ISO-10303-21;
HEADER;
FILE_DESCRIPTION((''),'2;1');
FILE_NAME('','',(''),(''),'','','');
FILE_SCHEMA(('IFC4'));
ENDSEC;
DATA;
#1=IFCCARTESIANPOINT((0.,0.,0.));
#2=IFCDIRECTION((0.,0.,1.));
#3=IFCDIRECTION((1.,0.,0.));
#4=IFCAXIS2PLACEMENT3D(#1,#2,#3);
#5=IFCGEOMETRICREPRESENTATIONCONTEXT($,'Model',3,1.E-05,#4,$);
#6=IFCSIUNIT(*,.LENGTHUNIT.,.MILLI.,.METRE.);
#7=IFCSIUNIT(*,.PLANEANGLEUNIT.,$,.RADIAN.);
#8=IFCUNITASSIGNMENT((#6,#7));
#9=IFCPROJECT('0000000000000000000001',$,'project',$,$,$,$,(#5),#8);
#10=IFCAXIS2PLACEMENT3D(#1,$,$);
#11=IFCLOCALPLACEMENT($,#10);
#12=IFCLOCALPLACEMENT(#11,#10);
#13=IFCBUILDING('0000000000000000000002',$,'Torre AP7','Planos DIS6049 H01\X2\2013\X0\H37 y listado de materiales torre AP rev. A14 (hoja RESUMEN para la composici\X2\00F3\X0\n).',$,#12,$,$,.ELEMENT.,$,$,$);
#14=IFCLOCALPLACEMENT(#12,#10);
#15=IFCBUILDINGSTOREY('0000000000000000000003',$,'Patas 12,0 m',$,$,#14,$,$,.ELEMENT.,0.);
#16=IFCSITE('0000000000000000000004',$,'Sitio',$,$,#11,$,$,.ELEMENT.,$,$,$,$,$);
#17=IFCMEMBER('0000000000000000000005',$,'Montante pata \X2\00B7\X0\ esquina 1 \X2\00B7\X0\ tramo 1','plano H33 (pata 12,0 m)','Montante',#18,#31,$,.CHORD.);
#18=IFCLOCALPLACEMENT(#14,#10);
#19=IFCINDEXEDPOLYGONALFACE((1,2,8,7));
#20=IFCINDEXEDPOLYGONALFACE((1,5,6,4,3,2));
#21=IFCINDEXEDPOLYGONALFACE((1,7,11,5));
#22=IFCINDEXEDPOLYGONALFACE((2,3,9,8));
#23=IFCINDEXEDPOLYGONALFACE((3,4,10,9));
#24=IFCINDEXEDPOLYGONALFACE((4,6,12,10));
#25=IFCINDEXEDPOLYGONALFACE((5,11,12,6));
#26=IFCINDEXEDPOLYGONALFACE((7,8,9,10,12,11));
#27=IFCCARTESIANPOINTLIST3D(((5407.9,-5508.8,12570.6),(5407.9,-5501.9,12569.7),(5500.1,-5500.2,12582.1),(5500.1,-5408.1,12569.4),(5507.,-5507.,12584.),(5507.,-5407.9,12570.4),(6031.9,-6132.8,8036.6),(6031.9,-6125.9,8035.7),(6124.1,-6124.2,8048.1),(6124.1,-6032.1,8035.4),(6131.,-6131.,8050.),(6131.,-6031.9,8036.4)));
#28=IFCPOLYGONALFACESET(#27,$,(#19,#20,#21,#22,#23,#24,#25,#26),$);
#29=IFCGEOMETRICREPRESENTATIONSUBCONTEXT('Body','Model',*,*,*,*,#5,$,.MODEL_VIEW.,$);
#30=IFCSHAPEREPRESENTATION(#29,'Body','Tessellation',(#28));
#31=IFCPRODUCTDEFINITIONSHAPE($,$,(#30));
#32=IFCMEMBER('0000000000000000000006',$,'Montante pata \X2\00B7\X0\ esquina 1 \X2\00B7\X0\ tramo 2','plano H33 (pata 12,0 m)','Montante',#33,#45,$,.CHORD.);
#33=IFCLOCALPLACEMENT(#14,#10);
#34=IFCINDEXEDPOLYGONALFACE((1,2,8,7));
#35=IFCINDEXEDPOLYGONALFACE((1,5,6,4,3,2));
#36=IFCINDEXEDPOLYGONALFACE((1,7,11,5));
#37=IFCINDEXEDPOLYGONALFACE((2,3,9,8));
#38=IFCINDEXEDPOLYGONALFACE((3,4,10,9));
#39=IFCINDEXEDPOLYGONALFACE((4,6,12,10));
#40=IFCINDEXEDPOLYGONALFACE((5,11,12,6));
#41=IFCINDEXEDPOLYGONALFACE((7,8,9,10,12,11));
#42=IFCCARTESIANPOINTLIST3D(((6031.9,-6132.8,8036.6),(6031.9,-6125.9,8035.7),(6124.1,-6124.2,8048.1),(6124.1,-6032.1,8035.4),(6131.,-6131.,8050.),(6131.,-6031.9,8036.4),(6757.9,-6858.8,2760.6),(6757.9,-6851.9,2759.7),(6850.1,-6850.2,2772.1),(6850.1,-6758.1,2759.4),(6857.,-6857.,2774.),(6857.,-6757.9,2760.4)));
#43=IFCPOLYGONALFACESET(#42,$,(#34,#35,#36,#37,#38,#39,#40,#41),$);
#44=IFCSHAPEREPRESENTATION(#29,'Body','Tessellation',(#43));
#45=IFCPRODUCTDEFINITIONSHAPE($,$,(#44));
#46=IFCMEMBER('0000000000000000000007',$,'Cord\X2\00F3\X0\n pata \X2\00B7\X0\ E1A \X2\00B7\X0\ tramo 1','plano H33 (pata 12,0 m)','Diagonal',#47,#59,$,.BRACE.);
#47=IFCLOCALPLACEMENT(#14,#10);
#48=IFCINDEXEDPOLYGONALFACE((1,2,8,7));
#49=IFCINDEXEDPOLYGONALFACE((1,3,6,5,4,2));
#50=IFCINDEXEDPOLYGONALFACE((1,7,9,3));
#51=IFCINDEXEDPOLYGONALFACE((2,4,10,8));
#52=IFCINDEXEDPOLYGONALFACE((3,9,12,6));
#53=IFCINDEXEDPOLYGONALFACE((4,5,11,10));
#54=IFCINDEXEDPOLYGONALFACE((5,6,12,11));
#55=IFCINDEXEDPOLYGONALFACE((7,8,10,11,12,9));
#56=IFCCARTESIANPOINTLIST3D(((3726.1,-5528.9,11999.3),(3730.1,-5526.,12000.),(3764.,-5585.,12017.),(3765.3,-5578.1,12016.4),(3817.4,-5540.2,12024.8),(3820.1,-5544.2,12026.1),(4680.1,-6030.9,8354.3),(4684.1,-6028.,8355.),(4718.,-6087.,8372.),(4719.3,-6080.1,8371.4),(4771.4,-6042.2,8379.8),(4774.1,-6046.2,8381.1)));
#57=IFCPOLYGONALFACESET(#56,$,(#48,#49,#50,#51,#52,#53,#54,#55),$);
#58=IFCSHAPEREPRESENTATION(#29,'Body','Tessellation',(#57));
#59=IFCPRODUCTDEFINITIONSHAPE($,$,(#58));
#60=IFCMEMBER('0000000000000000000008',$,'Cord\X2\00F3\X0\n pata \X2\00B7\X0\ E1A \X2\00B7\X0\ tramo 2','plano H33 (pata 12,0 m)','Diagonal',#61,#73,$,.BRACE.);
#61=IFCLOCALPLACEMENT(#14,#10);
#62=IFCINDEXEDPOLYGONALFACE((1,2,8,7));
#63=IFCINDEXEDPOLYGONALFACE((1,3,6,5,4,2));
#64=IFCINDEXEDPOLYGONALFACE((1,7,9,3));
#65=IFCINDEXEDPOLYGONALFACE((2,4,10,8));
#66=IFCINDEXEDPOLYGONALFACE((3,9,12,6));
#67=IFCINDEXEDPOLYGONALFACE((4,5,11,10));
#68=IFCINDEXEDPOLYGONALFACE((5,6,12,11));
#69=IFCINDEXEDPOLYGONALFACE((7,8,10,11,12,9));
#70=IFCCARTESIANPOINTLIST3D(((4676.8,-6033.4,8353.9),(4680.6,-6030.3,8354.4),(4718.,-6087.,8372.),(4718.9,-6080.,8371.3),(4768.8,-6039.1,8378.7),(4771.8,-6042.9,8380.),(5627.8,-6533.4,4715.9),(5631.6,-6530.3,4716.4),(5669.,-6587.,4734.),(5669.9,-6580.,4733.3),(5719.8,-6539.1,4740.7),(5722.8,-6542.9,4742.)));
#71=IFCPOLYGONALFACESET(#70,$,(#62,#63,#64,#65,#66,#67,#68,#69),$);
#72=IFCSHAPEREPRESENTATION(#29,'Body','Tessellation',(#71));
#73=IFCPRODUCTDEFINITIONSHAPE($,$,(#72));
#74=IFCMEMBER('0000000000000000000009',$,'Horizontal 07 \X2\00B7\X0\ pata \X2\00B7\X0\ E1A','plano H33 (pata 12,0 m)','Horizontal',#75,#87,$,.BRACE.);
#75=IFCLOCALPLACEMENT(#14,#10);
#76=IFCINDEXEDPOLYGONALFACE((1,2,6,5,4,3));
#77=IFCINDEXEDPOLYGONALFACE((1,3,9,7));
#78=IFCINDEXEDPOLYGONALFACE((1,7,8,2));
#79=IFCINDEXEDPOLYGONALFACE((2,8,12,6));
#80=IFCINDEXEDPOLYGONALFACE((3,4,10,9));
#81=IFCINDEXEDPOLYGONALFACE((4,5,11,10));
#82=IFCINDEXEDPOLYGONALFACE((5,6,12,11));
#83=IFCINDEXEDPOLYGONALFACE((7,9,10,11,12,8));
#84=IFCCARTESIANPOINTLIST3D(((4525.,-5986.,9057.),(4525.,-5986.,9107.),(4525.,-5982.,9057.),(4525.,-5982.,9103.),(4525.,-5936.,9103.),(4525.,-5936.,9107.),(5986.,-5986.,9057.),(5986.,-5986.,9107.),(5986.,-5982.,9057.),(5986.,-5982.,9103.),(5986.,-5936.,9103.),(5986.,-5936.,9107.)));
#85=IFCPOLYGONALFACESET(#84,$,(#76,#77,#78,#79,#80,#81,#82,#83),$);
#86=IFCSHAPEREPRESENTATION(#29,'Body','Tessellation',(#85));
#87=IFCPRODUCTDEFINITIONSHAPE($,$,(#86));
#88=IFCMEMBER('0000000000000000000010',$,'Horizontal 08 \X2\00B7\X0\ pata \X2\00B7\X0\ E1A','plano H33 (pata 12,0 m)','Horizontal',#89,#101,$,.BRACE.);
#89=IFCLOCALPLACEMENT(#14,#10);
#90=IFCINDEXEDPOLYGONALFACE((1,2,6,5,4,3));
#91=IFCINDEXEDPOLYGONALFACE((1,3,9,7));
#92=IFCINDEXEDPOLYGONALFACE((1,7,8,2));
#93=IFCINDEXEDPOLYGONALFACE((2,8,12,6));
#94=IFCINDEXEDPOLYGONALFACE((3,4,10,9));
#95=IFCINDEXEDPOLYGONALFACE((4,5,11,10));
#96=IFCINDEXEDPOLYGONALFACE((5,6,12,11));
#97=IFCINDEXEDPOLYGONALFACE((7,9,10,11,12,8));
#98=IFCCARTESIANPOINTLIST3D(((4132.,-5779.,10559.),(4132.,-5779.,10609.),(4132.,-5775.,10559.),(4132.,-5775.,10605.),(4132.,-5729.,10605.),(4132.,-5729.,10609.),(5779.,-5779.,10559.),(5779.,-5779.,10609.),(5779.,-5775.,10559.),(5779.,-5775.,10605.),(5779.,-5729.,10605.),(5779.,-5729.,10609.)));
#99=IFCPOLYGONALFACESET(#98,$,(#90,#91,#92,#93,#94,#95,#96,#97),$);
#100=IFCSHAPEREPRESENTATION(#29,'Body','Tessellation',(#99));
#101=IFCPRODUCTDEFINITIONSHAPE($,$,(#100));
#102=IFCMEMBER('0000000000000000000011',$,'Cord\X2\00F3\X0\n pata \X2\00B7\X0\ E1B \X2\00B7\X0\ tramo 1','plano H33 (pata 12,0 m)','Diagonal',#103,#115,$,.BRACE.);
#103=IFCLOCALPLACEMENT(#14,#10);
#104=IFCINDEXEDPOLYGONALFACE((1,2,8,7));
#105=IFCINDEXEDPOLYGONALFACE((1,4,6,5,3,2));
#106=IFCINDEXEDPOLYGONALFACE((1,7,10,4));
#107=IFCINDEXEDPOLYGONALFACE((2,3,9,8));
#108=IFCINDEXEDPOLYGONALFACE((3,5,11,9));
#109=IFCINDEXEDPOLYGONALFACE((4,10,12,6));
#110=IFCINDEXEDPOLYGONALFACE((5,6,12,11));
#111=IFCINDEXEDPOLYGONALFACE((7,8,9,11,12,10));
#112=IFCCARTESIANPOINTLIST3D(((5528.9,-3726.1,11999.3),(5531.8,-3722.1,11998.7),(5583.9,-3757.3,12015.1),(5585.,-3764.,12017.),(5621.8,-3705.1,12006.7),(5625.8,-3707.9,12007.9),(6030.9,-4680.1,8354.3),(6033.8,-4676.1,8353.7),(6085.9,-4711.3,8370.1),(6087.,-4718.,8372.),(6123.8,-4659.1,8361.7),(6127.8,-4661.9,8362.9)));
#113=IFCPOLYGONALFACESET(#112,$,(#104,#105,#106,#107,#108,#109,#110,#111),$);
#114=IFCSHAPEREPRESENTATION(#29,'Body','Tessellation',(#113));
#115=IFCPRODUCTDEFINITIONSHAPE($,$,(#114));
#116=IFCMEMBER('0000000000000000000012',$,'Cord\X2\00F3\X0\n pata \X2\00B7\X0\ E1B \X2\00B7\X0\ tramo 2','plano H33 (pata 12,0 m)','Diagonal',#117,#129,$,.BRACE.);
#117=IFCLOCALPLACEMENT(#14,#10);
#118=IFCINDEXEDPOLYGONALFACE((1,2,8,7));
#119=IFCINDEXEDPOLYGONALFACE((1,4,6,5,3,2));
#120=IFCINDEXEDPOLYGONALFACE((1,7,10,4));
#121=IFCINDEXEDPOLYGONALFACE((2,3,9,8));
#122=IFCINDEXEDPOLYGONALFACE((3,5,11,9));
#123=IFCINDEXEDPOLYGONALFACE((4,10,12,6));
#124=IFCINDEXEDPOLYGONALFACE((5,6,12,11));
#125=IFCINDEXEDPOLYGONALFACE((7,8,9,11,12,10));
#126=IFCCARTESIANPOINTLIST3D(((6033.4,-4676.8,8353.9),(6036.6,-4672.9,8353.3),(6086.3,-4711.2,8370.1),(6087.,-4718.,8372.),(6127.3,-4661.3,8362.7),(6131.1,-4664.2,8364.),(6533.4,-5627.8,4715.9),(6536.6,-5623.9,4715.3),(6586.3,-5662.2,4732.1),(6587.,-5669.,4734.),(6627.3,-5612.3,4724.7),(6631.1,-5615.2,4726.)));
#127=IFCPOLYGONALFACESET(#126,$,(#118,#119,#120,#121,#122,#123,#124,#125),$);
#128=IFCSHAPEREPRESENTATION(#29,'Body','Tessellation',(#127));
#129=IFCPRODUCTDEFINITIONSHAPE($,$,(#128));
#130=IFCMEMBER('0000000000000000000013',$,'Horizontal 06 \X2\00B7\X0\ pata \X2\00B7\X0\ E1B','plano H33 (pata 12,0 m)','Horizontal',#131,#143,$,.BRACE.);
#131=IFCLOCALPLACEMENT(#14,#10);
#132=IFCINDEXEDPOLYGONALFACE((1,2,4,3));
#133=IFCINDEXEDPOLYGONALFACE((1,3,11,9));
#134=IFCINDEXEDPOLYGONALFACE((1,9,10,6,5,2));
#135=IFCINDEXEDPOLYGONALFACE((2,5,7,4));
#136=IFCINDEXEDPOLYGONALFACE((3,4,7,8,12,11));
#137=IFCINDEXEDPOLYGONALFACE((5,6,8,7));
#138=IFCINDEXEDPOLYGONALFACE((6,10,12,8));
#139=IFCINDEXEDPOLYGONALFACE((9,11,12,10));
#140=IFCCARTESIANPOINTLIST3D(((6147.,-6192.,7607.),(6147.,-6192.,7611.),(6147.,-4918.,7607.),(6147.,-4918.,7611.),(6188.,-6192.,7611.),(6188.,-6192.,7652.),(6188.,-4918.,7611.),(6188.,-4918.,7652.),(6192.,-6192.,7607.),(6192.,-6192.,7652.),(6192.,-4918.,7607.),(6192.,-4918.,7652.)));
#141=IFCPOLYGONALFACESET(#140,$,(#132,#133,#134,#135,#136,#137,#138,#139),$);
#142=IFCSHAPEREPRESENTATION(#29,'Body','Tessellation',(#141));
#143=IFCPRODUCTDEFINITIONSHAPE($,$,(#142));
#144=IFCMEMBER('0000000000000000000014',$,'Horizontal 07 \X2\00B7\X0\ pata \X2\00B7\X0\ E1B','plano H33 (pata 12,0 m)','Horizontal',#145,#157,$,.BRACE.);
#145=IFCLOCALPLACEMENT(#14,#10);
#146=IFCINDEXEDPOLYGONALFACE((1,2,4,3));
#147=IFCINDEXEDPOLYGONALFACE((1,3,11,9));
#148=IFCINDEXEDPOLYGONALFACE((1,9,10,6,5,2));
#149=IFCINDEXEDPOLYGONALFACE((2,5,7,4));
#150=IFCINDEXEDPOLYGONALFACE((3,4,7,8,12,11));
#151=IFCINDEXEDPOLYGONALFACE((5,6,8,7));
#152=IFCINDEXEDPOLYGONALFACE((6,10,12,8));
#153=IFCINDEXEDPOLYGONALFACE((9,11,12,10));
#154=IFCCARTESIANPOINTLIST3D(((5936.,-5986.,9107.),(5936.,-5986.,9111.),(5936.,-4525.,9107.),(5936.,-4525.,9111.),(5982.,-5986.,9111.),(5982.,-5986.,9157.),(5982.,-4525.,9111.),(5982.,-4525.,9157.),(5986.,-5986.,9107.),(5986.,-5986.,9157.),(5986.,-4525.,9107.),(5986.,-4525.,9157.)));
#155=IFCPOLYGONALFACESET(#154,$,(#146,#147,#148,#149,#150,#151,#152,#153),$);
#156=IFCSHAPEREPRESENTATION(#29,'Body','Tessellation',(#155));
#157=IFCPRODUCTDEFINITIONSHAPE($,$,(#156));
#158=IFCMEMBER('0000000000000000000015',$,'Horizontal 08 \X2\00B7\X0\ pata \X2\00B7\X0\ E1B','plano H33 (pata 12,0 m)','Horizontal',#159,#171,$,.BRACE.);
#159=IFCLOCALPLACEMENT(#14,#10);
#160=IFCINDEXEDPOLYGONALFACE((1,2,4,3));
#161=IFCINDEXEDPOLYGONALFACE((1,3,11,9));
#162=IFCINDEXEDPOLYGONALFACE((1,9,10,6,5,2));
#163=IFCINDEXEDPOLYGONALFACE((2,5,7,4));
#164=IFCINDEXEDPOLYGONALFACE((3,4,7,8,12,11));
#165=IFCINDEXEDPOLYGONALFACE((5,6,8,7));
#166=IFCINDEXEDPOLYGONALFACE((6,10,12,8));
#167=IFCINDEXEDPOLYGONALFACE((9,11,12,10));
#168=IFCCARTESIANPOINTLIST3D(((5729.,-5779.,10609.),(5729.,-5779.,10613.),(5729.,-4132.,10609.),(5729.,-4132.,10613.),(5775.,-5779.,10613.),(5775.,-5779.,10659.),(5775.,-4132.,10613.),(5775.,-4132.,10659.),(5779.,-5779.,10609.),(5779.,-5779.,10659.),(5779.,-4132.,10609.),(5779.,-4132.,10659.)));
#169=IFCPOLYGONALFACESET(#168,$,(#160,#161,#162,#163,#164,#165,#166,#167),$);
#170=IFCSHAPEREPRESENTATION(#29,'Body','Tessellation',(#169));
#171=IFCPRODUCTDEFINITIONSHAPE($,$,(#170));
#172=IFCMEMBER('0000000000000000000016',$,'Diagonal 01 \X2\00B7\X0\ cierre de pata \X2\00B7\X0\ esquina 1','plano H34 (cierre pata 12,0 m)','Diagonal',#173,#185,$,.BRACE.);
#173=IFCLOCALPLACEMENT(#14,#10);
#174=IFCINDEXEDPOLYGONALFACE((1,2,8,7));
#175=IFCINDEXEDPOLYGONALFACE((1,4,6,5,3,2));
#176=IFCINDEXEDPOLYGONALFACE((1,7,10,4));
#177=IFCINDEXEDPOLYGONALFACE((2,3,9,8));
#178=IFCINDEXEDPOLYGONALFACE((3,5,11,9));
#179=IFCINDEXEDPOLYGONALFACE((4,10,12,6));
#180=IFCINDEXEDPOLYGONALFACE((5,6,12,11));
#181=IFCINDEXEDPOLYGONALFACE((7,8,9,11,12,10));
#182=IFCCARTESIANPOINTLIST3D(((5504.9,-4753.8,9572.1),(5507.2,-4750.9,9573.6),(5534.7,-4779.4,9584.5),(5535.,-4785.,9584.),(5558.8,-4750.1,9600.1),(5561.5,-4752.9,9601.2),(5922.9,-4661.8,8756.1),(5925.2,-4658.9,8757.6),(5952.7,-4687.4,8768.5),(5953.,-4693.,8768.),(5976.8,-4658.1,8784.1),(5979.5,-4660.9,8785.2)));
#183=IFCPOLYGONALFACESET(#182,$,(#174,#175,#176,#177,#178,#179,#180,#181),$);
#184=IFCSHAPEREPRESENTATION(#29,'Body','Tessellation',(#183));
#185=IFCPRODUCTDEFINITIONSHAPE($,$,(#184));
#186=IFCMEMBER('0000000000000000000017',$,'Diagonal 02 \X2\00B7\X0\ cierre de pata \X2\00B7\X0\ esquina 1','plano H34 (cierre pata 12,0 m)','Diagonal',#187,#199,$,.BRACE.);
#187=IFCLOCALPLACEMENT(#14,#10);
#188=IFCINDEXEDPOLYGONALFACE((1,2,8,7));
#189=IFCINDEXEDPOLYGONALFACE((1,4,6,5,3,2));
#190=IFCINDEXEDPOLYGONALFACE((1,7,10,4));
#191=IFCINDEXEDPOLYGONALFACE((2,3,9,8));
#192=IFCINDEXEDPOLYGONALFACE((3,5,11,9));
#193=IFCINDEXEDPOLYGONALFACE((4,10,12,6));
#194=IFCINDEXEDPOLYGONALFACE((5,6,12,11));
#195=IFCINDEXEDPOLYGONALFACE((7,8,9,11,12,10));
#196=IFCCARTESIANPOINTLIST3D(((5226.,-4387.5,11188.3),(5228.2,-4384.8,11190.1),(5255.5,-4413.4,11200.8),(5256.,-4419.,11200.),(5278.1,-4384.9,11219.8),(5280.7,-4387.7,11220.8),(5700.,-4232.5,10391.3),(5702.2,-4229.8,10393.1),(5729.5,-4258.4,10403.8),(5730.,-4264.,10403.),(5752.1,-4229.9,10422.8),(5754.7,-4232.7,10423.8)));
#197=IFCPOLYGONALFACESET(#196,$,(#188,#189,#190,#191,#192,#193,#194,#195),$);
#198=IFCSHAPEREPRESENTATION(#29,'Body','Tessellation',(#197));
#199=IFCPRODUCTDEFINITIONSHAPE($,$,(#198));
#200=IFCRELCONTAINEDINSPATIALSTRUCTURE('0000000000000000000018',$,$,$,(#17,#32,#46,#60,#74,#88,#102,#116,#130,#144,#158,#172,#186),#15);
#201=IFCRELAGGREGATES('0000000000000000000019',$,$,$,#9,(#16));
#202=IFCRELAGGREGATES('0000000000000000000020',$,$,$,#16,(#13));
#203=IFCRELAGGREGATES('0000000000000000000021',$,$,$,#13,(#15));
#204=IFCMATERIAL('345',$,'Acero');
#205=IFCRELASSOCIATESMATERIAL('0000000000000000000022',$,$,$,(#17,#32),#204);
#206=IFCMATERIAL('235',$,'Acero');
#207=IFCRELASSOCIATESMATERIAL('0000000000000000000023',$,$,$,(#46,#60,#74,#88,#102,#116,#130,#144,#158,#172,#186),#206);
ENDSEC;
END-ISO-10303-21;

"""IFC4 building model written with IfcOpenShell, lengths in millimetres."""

from ifc_helpers import new_model, si_unit, frame, frame_2d, origin, origin_with_axes, place, context, subcontext, project, spatial, l_section, extrude, material, element, save


model = new_model("IFC4")

# Units and contexts
model_context = context("Model", 3, precision=1e-05, world=origin_with_axes())
body_context = subcontext(model_context, "Body", "Model", "MODEL_VIEW")
ifc_project = project(units=[si_unit("LENGTHUNIT", "METRE", prefix="MILLI"), si_unit("PLANEANGLEUNIT", "RADIAN")], contexts=[model_context])

# Site, building, storey
site_placement = place(None, origin())
site = spatial("IfcSite", under=ifc_project, at=site_placement, Name="Sitio", CompositionType="ELEMENT")
building_placement = place(site_placement, origin())
building = spatial("IfcBuilding", under=site, at=building_placement, Name="Torre AP7", Description="Planos DIS6049 H01–H37 y listado de materiales torre AP rev. A14 (hoja RESUMEN para la composición).", CompositionType="ELEMENT")
storey_placement = place(building_placement, origin())
storey = spatial("IfcBuildingStorey", under=building, at=storey_placement, Name="Patas 12,0 m", CompositionType="ELEMENT", Elevation=0.0)

# Members
ifc_material_1 = material(Name="345", Category="Acero")
member_1_placement = place(storey_placement, frame((5507.0, -5507.0, 12584.0), z_axis=(0.135092, -0.135092, -0.981581), x_axis=(-0.990833, -0.018419, -0.13383)))
element("IfcMember", 1, at=member_1_placement, inside=storey, material=ifc_material_1, Name="Montante pata · esquina 1 · tramo 1", Description="plano H33 (pata 12,0 m)", ObjectType="Montante", PredefinedType="CHORD", context=body_context, shape_type="SweptSolid", body=[
    extrude(l_section(Depth=100.0, Width=100.0, Thickness=7.0, at=frame_2d((50.0, 50.0))), None, (0.0, 0.0, 1.0), 4619.1),
])
member_2_placement = place(storey_placement, frame((6131.0, -6131.0, 8050.0), z_axis=(0.13507, -0.13507, -0.981586), x_axis=(-0.990836, -0.018413, -0.13381)))
element("IfcMember", 2, at=member_2_placement, inside=storey, material=ifc_material_1, Name="Montante pata · esquina 1 · tramo 2", Description="plano H33 (pata 12,0 m)", ObjectType="Montante", PredefinedType="CHORD", context=body_context, shape_type="SweptSolid", body=[
    extrude(l_section(Depth=100.0, Width=100.0, Thickness=7.0, at=frame_2d((50.0, 50.0))), None, (0.0, 0.0, 1.0), 5375.0),
])
ifc_material_2 = material(Name="235", Category="Acero")
member_3_placement = place(storey_placement, frame((3764.0, -5585.0, 12017.0), z_axis=(0.250982, -0.132068, -0.95894), x_axis=(-0.541846, 0.801736, -0.252234)))
element("IfcMember", 3, at=member_3_placement, inside=storey, material=ifc_material_2, Name="Cordón pata · E1A · tramo 1", Description="plano H33 (pata 12,0 m)", ObjectType="Diagonal", PredefinedType="BRACE", context=body_context, shape_type="SweptSolid", body=[
    extrude(l_section(Depth=70.0, Width=70.0, Thickness=5.0, at=frame_2d((35.0, 35.0))), None, (0.0, 0.0, 1.0), 3801.1),
])
member_4_placement = place(storey_placement, frame((4718.0, -6087.0, 8372.0), z_axis=(0.250702, -0.13181, -0.959049), x_axis=(-0.588862, 0.76556, -0.25915)))
element("IfcMember", 4, at=member_4_placement, inside=storey, material=ifc_material_2, Name="Cordón pata · E1A · tramo 2", Description="plano H33 (pata 12,0 m)", ObjectType="Diagonal", PredefinedType="BRACE", context=body_context, shape_type="SweptSolid", body=[
    extrude(l_section(Depth=70.0, Width=70.0, Thickness=5.0, at=frame_2d((35.0, 35.0))), None, (0.0, 0.0, 1.0), 3793.3),
])
member_5_placement = place(storey_placement, frame((5986.0, -5986.0, 9107.0), z_axis=(-1.0, 0.0, 0.0), x_axis=(0.0, 1.0, 0.0)))
element("IfcMember", 5, at=member_5_placement, inside=storey, material=ifc_material_2, Name="Horizontal 07 · pata · E1A", Description="plano H33 (pata 12,0 m)", ObjectType="Horizontal", PredefinedType="BRACE", context=body_context, shape_type="SweptSolid", body=[
    extrude(l_section(Depth=50.0, Width=50.0, Thickness=4.0, at=frame_2d((25.0, 25.0))), None, (0.0, 0.0, 1.0), 1461.0),
])
member_6_placement = place(storey_placement, frame((5779.0, -5779.0, 10609.0), z_axis=(-1.0, 0.0, 0.0), x_axis=(0.0, 1.0, 0.0)))
element("IfcMember", 6, at=member_6_placement, inside=storey, material=ifc_material_2, Name="Horizontal 08 · pata · E1A", Description="plano H33 (pata 12,0 m)", ObjectType="Horizontal", PredefinedType="BRACE", context=body_context, shape_type="SweptSolid", body=[
    extrude(l_section(Depth=50.0, Width=50.0, Thickness=4.0, at=frame_2d((25.0, 25.0))), None, (0.0, 0.0, 1.0), 1647.0),
])
member_7_placement = place(storey_placement, frame((5585.0, -3764.0, 12017.0), z_axis=(0.132068, -0.250982, -0.95894), x_axis=(-0.801736, 0.541846, -0.252234)))
element("IfcMember", 7, at=member_7_placement, inside=storey, material=ifc_material_2, Name="Cordón pata · E1B · tramo 1", Description="plano H33 (pata 12,0 m)", ObjectType="Diagonal", PredefinedType="BRACE", context=body_context, shape_type="SweptSolid", body=[
    extrude(l_section(Depth=70.0, Width=70.0, Thickness=5.0, at=frame_2d((35.0, 35.0))), None, (0.0, 0.0, 1.0), 3801.1),
])
member_8_placement = place(storey_placement, frame((6087.0, -4718.0, 8372.0), z_axis=(0.13181, -0.250702, -0.959049), x_axis=(-0.76556, 0.588862, -0.25915)))
element("IfcMember", 8, at=member_8_placement, inside=storey, material=ifc_material_2, Name="Cordón pata · E1B · tramo 2", Description="plano H33 (pata 12,0 m)", ObjectType="Diagonal", PredefinedType="BRACE", context=body_context, shape_type="SweptSolid", body=[
    extrude(l_section(Depth=70.0, Width=70.0, Thickness=5.0, at=frame_2d((35.0, 35.0))), None, (0.0, 0.0, 1.0), 3793.3),
])
member_9_placement = place(storey_placement, frame((6192.0, -6192.0, 7607.0), z_axis=(0.0, 1.0, 0.0), x_axis=(-1.0, 0.0, 0.0)))
element("IfcMember", 9, at=member_9_placement, inside=storey, material=ifc_material_2, Name="Horizontal 06 · pata · E1B", Description="plano H33 (pata 12,0 m)", ObjectType="Horizontal", PredefinedType="BRACE", context=body_context, shape_type="SweptSolid", body=[
    extrude(l_section(Depth=45.0, Width=45.0, Thickness=4.0, at=frame_2d((22.5, 22.5))), None, (0.0, 0.0, 1.0), 1274.0),
])
member_10_placement = place(storey_placement, frame((5986.0, -5986.0, 9107.0), z_axis=(0.0, 1.0, 0.0), x_axis=(-1.0, 0.0, 0.0)))
element("IfcMember", 10, at=member_10_placement, inside=storey, material=ifc_material_2, Name="Horizontal 07 · pata · E1B", Description="plano H33 (pata 12,0 m)", ObjectType="Horizontal", PredefinedType="BRACE", context=body_context, shape_type="SweptSolid", body=[
    extrude(l_section(Depth=50.0, Width=50.0, Thickness=4.0, at=frame_2d((25.0, 25.0))), None, (0.0, 0.0, 1.0), 1461.0),
])
member_11_placement = place(storey_placement, frame((5779.0, -5779.0, 10609.0), z_axis=(0.0, 1.0, 0.0), x_axis=(-1.0, 0.0, 0.0)))
element("IfcMember", 11, at=member_11_placement, inside=storey, material=ifc_material_2, Name="Horizontal 08 · pata · E1B", Description="plano H33 (pata 12,0 m)", ObjectType="Horizontal", PredefinedType="BRACE", context=body_context, shape_type="SweptSolid", body=[
    extrude(l_section(Depth=50.0, Width=50.0, Thickness=4.0, at=frame_2d((25.0, 25.0))), None, (0.0, 0.0, 1.0), 1647.0),
])
member_12_placement = place(storey_placement, frame((5535.0, -4785.0, 9584.0), z_axis=(0.45364, 0.099844, -0.885574), x_axis=(-0.669488, 0.694062, -0.264696)))
element("IfcMember", 12, at=member_12_placement, inside=storey, material=ifc_material_2, Name="Diagonal 01 · cierre de pata · esquina 1", Description="plano H34 (cierre pata 12,0 m)", ObjectType="Diagonal", PredefinedType="BRACE", context=body_context, shape_type="SweptSolid", body=[
    extrude(l_section(Depth=45.0, Width=45.0, Thickness=4.0, at=frame_2d((22.5, 22.5))), None, (0.0, 0.0, 1.0), 921.4),
])
member_13_placement = place(storey_placement, frame((5256.0, -4419.0, 11200.0), z_axis=(0.504167, 0.164865, -0.847724), x_axis=(-0.665954, 0.699186, -0.260086)))
element("IfcMember", 13, at=member_13_placement, inside=storey, material=ifc_material_2, Name="Diagonal 02 · cierre de pata · esquina 1", Description="plano H34 (cierre pata 12,0 m)", ObjectType="Diagonal", PredefinedType="BRACE", context=body_context, shape_type="SweptSolid", body=[
    extrude(l_section(Depth=45.0, Width=45.0, Thickness=4.0, at=frame_2d((22.5, 22.5))), None, (0.0, 0.0, 1.0), 940.2),
])

save(model, "model.ifc")
